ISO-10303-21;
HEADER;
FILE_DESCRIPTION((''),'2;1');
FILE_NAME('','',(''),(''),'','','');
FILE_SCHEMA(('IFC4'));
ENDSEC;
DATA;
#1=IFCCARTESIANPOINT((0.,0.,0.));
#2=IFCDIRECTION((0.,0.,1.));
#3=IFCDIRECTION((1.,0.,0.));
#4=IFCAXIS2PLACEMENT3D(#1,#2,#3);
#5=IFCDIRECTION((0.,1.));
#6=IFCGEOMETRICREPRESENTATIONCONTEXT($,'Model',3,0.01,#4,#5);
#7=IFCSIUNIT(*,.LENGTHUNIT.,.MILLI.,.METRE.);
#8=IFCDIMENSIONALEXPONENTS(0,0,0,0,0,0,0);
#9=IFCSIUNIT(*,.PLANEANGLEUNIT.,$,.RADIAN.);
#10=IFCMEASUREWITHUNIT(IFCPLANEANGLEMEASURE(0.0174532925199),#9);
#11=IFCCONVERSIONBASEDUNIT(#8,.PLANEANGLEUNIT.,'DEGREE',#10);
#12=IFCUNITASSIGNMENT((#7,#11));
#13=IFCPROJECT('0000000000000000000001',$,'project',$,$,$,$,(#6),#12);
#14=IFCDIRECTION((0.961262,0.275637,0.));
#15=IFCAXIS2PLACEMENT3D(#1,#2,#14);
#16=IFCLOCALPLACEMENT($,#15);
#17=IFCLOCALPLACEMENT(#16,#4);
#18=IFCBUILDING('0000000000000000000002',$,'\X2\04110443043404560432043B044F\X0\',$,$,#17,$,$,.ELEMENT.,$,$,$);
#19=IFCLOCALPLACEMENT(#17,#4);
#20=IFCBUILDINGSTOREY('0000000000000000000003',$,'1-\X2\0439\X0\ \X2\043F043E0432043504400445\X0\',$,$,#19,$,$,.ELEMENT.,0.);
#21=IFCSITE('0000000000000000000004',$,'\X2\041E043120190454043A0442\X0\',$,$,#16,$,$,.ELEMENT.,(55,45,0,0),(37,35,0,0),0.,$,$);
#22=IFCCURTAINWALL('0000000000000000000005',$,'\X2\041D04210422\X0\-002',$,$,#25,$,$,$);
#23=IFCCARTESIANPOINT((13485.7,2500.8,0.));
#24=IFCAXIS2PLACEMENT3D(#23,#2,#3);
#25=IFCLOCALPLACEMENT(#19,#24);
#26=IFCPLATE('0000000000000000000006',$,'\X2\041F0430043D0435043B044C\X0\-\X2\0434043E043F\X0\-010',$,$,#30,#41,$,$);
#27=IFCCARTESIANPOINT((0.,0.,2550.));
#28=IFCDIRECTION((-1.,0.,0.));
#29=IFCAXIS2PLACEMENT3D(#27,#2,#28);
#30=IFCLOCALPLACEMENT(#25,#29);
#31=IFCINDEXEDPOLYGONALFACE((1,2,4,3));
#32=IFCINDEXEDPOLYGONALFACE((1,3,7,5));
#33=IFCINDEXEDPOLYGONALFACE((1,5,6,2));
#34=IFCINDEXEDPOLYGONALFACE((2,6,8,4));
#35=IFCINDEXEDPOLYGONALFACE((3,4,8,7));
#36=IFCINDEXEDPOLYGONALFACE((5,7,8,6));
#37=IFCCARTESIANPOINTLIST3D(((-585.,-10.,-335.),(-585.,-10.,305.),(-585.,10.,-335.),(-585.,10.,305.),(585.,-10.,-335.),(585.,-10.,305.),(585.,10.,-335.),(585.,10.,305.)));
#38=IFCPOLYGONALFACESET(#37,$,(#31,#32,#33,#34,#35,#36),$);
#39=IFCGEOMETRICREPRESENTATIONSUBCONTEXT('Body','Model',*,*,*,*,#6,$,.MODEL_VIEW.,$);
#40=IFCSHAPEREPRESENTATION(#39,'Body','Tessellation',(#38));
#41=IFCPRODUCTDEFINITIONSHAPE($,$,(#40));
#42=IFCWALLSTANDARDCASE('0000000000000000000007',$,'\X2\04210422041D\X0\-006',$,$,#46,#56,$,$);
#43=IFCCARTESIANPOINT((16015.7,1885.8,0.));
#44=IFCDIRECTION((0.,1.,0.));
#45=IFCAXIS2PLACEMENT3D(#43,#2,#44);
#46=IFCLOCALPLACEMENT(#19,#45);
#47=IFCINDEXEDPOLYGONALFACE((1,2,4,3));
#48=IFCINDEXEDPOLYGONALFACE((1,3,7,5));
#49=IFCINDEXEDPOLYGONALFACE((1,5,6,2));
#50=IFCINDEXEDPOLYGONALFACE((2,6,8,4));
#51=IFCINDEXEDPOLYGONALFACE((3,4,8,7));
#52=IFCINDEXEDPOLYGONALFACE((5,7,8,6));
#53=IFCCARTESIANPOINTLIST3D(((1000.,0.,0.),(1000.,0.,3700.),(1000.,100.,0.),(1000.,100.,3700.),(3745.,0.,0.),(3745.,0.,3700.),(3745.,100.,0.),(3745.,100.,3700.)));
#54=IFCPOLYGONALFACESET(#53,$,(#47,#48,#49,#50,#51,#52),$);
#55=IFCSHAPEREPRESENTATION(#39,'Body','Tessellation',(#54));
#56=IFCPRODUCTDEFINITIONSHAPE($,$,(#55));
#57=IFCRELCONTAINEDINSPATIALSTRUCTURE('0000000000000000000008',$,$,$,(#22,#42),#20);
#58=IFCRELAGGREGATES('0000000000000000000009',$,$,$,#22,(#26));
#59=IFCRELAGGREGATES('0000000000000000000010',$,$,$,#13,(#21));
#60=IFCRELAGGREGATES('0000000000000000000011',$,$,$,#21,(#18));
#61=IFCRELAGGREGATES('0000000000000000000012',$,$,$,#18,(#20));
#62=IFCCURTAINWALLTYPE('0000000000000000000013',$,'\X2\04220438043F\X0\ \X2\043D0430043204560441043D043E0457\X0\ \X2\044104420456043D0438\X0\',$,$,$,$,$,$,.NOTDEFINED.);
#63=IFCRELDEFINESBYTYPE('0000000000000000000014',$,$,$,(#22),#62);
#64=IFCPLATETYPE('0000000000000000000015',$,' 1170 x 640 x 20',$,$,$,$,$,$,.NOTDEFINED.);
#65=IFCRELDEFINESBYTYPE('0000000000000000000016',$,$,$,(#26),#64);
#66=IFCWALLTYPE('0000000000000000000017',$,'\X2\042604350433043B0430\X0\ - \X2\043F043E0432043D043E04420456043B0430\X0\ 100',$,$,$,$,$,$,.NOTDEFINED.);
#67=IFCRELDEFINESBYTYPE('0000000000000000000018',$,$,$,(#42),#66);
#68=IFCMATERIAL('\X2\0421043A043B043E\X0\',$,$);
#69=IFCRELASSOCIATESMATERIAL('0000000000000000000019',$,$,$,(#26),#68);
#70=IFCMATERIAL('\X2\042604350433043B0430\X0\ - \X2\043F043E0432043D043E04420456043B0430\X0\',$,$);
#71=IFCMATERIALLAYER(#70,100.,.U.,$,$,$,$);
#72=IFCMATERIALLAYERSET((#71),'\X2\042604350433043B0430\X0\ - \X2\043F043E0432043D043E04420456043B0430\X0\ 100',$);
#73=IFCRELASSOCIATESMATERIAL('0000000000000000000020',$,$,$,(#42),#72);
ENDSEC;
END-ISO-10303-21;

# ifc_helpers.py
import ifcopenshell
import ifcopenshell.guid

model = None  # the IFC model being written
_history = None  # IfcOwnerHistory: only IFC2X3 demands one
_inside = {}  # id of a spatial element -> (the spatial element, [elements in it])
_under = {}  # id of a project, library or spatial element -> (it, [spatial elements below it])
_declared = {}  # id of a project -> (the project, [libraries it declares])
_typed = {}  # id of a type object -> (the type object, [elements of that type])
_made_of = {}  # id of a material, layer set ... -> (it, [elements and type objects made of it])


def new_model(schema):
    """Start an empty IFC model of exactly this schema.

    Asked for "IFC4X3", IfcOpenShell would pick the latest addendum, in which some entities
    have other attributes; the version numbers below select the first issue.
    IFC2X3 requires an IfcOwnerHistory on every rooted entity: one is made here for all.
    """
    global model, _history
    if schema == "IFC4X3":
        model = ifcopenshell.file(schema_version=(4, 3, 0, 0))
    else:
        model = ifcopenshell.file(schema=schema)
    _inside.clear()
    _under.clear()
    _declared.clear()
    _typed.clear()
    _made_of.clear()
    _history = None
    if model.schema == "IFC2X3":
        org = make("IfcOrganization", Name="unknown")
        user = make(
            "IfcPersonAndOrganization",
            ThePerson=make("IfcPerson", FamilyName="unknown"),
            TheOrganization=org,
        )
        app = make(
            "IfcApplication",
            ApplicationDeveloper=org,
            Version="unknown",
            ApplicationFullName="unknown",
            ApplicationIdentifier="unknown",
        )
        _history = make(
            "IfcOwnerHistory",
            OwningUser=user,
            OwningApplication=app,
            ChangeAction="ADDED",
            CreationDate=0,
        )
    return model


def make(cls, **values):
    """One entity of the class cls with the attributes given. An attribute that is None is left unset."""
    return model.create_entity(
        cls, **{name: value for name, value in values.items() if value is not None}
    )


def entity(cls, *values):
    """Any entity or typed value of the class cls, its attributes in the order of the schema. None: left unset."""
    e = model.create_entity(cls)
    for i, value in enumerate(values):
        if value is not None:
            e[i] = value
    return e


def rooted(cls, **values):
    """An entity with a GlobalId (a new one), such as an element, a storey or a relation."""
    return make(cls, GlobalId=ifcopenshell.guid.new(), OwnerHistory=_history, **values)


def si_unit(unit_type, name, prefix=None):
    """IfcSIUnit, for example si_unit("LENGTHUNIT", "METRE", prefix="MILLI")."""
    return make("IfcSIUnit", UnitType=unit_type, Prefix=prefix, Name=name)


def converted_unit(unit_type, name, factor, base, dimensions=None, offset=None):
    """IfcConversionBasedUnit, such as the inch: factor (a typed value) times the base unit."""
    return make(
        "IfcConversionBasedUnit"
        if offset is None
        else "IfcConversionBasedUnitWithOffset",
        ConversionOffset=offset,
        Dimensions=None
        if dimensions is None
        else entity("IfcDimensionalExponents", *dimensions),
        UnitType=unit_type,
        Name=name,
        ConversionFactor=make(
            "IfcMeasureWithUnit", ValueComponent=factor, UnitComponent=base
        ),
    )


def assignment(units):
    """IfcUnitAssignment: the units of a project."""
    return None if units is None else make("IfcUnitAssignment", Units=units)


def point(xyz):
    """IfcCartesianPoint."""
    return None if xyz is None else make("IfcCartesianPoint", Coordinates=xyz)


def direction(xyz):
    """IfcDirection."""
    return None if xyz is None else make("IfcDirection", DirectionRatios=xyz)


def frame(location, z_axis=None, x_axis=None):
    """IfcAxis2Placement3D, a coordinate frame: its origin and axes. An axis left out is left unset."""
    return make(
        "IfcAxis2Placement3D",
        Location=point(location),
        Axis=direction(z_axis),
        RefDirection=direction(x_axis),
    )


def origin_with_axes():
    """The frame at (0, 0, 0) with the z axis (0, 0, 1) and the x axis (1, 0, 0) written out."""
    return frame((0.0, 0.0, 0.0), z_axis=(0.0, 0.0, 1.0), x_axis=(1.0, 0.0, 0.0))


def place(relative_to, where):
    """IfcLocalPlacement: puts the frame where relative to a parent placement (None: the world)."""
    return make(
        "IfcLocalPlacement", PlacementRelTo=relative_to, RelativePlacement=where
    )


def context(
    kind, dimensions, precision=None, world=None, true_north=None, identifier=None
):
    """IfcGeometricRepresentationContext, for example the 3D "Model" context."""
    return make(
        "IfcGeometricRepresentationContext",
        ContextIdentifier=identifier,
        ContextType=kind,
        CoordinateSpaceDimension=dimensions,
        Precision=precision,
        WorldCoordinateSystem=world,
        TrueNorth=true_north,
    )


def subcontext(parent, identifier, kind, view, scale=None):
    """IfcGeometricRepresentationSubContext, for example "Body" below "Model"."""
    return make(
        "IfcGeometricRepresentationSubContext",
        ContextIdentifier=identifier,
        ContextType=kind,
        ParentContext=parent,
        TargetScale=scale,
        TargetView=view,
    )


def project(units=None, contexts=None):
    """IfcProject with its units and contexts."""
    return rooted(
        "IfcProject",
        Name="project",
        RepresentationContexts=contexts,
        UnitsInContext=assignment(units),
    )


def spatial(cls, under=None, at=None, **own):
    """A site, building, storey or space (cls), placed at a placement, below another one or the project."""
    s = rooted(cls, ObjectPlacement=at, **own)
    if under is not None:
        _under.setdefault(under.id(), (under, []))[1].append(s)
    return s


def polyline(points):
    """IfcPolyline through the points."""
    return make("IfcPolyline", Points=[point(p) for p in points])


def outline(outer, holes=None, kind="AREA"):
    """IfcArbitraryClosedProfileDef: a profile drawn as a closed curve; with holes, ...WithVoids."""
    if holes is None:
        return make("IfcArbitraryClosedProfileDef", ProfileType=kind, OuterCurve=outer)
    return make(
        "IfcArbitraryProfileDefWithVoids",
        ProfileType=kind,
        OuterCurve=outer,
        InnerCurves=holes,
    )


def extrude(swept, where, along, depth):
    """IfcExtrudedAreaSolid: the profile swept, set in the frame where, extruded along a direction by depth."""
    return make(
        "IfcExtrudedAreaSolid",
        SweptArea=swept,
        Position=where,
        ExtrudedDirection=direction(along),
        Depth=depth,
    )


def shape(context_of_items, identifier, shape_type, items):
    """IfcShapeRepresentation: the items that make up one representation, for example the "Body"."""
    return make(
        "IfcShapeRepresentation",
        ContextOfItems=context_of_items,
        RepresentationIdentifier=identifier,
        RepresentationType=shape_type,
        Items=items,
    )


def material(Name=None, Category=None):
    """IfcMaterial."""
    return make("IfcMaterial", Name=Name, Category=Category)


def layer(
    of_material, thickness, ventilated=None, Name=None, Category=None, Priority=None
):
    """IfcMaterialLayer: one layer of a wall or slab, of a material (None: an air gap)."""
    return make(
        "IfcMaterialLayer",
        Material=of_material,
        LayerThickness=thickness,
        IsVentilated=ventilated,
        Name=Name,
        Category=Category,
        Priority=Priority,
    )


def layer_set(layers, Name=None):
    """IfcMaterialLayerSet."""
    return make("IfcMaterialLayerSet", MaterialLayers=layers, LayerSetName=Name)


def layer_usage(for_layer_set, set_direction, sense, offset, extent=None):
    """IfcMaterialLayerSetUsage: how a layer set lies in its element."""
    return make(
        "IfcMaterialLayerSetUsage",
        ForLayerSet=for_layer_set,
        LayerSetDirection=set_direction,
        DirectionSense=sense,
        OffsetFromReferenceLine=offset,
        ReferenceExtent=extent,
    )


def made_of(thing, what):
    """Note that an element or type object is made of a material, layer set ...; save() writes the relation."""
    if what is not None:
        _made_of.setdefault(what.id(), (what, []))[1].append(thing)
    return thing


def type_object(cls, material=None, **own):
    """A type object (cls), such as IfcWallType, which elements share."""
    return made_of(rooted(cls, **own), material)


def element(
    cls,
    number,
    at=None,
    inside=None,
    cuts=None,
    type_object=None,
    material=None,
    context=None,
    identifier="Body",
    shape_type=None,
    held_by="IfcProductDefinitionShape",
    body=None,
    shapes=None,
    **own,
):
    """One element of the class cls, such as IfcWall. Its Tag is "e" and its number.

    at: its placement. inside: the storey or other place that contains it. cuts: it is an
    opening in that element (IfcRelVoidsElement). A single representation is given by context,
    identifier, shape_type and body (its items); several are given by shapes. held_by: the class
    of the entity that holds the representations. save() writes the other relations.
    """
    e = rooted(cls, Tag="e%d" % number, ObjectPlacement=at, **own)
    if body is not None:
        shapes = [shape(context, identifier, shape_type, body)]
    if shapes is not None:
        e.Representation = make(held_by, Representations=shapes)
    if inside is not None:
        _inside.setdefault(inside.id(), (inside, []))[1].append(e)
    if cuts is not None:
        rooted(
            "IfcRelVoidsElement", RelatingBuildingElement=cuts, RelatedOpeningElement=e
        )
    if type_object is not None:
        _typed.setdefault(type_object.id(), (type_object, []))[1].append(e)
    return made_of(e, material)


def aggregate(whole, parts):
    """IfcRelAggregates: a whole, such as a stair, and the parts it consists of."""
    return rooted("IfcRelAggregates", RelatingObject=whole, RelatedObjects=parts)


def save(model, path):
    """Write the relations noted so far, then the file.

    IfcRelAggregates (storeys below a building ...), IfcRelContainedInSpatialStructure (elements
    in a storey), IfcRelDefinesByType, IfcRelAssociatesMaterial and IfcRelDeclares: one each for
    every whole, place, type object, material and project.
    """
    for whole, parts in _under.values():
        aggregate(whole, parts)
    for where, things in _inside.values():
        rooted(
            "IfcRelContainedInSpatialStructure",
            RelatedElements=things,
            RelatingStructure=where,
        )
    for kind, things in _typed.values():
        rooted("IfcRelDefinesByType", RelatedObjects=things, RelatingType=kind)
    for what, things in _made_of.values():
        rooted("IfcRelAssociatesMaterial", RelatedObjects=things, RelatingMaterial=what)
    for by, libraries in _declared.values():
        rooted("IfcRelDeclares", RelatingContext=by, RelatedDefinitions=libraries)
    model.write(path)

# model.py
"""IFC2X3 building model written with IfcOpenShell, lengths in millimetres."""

from ifc_helpers import new_model, entity, si_unit, converted_unit, direction, frame, origin_with_axes, place, context, subcontext, project, spatial, polyline, outline, extrude, material, layer, layer_set, layer_usage, type_object, element, aggregate, save


model = new_model("IFC2X3")

# Units and contexts
model_context = context("Model", 3, precision=0.01, world=origin_with_axes(), true_north=direction((0.0, 1.0)))
body_context = subcontext(model_context, "Body", "Model", "MODEL_VIEW")
ifc_project = project(units=[si_unit("LENGTHUNIT", "METRE", prefix="MILLI"), converted_unit("PLANEANGLEUNIT", "DEGREE", entity("IfcPlaneAngleMeasure", 0.0174532925199), si_unit("PLANEANGLEUNIT", "RADIAN"), dimensions=[0, 0, 0, 0, 0, 0, 0])], contexts=[model_context])

# Site, building, storey
site_placement = place(None, frame((0.0, 0.0, 0.0), z_axis=(0.0, 0.0, 1.0), x_axis=(0.961262, 0.275637, 0.0)))
site = spatial("IfcSite", under=ifc_project, at=site_placement, Name="Об’єкт", CompositionType="ELEMENT", RefLatitude=(55, 45, 0, 0), RefLongitude=(37, 35, 0, 0), RefElevation=0.0)
building_placement = place(site_placement, origin_with_axes())
building = spatial("IfcBuilding", under=site, at=building_placement, Name="Будівля", CompositionType="ELEMENT")
storey_placement = place(building_placement, origin_with_axes())
storey = spatial("IfcBuildingStorey", under=building, at=storey_placement, Name="1-й поверх", CompositionType="ELEMENT", Elevation=0.0)

# Curtain wall
curtain_wall_type = type_object("IfcCurtainWallType", Name="Тип навісної стіни", PredefinedType="NOTDEFINED")
curtain_wall_placement = place(storey_placement, frame((13485.7, 2500.8, 0.0), z_axis=(0.0, 0.0, 1.0), x_axis=(1.0, 0.0, 0.0)))
curtain_wall = element("IfcCurtainWall", 1, at=curtain_wall_placement, inside=storey, type_object=curtain_wall_type, Name="НСТ-002")

# Plate
ifc_material_1 = material(Name="Скло")
plate_type = type_object("IfcPlateType", Name=" 1170 x 640 x 20", PredefinedType="NOTDEFINED")
plate_placement = place(curtain_wall_placement, frame((0.0, 0.0, 2550.0), z_axis=(0.0, 0.0, 1.0), x_axis=(-1.0, 0.0, 0.0)))
plate = element("IfcPlate", 2, at=plate_placement, type_object=plate_type, material=ifc_material_1, Name="Панель-доп-010", context=body_context, shape_type="SweptSolid", body=[
    extrude(outline(polyline([(-585.0, -305.0), (585.0, -305.0), (585.0, 335.0), (-585.0, 335.0), (-585.0, -305.0)])), frame((0.0, -10.0, 0.0), z_axis=(0.0, 1.0, 0.0), x_axis=(1.0, 0.0, 0.0)), (0.0, 0.0, 1.0), 20.0),
])
aggregate(curtain_wall, [plate])

# Wall
ifc_material_2 = material(Name="Цегла - повнотіла")
ifc_layer_1 = layer(ifc_material_2, 100.0, ventilated="UNKNOWN")
ifc_layer_set_1 = layer_set([ifc_layer_1], Name="Цегла - повнотіла 100")
ifc_layer_usage_1 = layer_usage(ifc_layer_set_1, "AXIS2", "POSITIVE", 0.0)
wall_type_1 = type_object("IfcWallType", Name="Цегла - повнотіла 100", PredefinedType="NOTDEFINED")
wall_1_placement = place(storey_placement, frame((16015.7, 1885.8, 0.0), z_axis=(0.0, 0.0, 1.0), x_axis=(0.0, 1.0, 0.0)))
element("IfcWallStandardCase", 3, at=wall_1_placement, inside=storey, type_object=wall_type_1, material=ifc_layer_usage_1, Name="СТН-006", context=body_context, shape_type="SweptSolid", body=[
    extrude(outline(polyline([(1000.0, 0.0), (3745.0, 0.0), (3745.0, 100.0), (1000.0, 100.0), (1000.0, 0.0)])), origin_with_axes(), (0.0, 0.0, 1.0), 3700.0),
])

save(model, "model.ifc")
